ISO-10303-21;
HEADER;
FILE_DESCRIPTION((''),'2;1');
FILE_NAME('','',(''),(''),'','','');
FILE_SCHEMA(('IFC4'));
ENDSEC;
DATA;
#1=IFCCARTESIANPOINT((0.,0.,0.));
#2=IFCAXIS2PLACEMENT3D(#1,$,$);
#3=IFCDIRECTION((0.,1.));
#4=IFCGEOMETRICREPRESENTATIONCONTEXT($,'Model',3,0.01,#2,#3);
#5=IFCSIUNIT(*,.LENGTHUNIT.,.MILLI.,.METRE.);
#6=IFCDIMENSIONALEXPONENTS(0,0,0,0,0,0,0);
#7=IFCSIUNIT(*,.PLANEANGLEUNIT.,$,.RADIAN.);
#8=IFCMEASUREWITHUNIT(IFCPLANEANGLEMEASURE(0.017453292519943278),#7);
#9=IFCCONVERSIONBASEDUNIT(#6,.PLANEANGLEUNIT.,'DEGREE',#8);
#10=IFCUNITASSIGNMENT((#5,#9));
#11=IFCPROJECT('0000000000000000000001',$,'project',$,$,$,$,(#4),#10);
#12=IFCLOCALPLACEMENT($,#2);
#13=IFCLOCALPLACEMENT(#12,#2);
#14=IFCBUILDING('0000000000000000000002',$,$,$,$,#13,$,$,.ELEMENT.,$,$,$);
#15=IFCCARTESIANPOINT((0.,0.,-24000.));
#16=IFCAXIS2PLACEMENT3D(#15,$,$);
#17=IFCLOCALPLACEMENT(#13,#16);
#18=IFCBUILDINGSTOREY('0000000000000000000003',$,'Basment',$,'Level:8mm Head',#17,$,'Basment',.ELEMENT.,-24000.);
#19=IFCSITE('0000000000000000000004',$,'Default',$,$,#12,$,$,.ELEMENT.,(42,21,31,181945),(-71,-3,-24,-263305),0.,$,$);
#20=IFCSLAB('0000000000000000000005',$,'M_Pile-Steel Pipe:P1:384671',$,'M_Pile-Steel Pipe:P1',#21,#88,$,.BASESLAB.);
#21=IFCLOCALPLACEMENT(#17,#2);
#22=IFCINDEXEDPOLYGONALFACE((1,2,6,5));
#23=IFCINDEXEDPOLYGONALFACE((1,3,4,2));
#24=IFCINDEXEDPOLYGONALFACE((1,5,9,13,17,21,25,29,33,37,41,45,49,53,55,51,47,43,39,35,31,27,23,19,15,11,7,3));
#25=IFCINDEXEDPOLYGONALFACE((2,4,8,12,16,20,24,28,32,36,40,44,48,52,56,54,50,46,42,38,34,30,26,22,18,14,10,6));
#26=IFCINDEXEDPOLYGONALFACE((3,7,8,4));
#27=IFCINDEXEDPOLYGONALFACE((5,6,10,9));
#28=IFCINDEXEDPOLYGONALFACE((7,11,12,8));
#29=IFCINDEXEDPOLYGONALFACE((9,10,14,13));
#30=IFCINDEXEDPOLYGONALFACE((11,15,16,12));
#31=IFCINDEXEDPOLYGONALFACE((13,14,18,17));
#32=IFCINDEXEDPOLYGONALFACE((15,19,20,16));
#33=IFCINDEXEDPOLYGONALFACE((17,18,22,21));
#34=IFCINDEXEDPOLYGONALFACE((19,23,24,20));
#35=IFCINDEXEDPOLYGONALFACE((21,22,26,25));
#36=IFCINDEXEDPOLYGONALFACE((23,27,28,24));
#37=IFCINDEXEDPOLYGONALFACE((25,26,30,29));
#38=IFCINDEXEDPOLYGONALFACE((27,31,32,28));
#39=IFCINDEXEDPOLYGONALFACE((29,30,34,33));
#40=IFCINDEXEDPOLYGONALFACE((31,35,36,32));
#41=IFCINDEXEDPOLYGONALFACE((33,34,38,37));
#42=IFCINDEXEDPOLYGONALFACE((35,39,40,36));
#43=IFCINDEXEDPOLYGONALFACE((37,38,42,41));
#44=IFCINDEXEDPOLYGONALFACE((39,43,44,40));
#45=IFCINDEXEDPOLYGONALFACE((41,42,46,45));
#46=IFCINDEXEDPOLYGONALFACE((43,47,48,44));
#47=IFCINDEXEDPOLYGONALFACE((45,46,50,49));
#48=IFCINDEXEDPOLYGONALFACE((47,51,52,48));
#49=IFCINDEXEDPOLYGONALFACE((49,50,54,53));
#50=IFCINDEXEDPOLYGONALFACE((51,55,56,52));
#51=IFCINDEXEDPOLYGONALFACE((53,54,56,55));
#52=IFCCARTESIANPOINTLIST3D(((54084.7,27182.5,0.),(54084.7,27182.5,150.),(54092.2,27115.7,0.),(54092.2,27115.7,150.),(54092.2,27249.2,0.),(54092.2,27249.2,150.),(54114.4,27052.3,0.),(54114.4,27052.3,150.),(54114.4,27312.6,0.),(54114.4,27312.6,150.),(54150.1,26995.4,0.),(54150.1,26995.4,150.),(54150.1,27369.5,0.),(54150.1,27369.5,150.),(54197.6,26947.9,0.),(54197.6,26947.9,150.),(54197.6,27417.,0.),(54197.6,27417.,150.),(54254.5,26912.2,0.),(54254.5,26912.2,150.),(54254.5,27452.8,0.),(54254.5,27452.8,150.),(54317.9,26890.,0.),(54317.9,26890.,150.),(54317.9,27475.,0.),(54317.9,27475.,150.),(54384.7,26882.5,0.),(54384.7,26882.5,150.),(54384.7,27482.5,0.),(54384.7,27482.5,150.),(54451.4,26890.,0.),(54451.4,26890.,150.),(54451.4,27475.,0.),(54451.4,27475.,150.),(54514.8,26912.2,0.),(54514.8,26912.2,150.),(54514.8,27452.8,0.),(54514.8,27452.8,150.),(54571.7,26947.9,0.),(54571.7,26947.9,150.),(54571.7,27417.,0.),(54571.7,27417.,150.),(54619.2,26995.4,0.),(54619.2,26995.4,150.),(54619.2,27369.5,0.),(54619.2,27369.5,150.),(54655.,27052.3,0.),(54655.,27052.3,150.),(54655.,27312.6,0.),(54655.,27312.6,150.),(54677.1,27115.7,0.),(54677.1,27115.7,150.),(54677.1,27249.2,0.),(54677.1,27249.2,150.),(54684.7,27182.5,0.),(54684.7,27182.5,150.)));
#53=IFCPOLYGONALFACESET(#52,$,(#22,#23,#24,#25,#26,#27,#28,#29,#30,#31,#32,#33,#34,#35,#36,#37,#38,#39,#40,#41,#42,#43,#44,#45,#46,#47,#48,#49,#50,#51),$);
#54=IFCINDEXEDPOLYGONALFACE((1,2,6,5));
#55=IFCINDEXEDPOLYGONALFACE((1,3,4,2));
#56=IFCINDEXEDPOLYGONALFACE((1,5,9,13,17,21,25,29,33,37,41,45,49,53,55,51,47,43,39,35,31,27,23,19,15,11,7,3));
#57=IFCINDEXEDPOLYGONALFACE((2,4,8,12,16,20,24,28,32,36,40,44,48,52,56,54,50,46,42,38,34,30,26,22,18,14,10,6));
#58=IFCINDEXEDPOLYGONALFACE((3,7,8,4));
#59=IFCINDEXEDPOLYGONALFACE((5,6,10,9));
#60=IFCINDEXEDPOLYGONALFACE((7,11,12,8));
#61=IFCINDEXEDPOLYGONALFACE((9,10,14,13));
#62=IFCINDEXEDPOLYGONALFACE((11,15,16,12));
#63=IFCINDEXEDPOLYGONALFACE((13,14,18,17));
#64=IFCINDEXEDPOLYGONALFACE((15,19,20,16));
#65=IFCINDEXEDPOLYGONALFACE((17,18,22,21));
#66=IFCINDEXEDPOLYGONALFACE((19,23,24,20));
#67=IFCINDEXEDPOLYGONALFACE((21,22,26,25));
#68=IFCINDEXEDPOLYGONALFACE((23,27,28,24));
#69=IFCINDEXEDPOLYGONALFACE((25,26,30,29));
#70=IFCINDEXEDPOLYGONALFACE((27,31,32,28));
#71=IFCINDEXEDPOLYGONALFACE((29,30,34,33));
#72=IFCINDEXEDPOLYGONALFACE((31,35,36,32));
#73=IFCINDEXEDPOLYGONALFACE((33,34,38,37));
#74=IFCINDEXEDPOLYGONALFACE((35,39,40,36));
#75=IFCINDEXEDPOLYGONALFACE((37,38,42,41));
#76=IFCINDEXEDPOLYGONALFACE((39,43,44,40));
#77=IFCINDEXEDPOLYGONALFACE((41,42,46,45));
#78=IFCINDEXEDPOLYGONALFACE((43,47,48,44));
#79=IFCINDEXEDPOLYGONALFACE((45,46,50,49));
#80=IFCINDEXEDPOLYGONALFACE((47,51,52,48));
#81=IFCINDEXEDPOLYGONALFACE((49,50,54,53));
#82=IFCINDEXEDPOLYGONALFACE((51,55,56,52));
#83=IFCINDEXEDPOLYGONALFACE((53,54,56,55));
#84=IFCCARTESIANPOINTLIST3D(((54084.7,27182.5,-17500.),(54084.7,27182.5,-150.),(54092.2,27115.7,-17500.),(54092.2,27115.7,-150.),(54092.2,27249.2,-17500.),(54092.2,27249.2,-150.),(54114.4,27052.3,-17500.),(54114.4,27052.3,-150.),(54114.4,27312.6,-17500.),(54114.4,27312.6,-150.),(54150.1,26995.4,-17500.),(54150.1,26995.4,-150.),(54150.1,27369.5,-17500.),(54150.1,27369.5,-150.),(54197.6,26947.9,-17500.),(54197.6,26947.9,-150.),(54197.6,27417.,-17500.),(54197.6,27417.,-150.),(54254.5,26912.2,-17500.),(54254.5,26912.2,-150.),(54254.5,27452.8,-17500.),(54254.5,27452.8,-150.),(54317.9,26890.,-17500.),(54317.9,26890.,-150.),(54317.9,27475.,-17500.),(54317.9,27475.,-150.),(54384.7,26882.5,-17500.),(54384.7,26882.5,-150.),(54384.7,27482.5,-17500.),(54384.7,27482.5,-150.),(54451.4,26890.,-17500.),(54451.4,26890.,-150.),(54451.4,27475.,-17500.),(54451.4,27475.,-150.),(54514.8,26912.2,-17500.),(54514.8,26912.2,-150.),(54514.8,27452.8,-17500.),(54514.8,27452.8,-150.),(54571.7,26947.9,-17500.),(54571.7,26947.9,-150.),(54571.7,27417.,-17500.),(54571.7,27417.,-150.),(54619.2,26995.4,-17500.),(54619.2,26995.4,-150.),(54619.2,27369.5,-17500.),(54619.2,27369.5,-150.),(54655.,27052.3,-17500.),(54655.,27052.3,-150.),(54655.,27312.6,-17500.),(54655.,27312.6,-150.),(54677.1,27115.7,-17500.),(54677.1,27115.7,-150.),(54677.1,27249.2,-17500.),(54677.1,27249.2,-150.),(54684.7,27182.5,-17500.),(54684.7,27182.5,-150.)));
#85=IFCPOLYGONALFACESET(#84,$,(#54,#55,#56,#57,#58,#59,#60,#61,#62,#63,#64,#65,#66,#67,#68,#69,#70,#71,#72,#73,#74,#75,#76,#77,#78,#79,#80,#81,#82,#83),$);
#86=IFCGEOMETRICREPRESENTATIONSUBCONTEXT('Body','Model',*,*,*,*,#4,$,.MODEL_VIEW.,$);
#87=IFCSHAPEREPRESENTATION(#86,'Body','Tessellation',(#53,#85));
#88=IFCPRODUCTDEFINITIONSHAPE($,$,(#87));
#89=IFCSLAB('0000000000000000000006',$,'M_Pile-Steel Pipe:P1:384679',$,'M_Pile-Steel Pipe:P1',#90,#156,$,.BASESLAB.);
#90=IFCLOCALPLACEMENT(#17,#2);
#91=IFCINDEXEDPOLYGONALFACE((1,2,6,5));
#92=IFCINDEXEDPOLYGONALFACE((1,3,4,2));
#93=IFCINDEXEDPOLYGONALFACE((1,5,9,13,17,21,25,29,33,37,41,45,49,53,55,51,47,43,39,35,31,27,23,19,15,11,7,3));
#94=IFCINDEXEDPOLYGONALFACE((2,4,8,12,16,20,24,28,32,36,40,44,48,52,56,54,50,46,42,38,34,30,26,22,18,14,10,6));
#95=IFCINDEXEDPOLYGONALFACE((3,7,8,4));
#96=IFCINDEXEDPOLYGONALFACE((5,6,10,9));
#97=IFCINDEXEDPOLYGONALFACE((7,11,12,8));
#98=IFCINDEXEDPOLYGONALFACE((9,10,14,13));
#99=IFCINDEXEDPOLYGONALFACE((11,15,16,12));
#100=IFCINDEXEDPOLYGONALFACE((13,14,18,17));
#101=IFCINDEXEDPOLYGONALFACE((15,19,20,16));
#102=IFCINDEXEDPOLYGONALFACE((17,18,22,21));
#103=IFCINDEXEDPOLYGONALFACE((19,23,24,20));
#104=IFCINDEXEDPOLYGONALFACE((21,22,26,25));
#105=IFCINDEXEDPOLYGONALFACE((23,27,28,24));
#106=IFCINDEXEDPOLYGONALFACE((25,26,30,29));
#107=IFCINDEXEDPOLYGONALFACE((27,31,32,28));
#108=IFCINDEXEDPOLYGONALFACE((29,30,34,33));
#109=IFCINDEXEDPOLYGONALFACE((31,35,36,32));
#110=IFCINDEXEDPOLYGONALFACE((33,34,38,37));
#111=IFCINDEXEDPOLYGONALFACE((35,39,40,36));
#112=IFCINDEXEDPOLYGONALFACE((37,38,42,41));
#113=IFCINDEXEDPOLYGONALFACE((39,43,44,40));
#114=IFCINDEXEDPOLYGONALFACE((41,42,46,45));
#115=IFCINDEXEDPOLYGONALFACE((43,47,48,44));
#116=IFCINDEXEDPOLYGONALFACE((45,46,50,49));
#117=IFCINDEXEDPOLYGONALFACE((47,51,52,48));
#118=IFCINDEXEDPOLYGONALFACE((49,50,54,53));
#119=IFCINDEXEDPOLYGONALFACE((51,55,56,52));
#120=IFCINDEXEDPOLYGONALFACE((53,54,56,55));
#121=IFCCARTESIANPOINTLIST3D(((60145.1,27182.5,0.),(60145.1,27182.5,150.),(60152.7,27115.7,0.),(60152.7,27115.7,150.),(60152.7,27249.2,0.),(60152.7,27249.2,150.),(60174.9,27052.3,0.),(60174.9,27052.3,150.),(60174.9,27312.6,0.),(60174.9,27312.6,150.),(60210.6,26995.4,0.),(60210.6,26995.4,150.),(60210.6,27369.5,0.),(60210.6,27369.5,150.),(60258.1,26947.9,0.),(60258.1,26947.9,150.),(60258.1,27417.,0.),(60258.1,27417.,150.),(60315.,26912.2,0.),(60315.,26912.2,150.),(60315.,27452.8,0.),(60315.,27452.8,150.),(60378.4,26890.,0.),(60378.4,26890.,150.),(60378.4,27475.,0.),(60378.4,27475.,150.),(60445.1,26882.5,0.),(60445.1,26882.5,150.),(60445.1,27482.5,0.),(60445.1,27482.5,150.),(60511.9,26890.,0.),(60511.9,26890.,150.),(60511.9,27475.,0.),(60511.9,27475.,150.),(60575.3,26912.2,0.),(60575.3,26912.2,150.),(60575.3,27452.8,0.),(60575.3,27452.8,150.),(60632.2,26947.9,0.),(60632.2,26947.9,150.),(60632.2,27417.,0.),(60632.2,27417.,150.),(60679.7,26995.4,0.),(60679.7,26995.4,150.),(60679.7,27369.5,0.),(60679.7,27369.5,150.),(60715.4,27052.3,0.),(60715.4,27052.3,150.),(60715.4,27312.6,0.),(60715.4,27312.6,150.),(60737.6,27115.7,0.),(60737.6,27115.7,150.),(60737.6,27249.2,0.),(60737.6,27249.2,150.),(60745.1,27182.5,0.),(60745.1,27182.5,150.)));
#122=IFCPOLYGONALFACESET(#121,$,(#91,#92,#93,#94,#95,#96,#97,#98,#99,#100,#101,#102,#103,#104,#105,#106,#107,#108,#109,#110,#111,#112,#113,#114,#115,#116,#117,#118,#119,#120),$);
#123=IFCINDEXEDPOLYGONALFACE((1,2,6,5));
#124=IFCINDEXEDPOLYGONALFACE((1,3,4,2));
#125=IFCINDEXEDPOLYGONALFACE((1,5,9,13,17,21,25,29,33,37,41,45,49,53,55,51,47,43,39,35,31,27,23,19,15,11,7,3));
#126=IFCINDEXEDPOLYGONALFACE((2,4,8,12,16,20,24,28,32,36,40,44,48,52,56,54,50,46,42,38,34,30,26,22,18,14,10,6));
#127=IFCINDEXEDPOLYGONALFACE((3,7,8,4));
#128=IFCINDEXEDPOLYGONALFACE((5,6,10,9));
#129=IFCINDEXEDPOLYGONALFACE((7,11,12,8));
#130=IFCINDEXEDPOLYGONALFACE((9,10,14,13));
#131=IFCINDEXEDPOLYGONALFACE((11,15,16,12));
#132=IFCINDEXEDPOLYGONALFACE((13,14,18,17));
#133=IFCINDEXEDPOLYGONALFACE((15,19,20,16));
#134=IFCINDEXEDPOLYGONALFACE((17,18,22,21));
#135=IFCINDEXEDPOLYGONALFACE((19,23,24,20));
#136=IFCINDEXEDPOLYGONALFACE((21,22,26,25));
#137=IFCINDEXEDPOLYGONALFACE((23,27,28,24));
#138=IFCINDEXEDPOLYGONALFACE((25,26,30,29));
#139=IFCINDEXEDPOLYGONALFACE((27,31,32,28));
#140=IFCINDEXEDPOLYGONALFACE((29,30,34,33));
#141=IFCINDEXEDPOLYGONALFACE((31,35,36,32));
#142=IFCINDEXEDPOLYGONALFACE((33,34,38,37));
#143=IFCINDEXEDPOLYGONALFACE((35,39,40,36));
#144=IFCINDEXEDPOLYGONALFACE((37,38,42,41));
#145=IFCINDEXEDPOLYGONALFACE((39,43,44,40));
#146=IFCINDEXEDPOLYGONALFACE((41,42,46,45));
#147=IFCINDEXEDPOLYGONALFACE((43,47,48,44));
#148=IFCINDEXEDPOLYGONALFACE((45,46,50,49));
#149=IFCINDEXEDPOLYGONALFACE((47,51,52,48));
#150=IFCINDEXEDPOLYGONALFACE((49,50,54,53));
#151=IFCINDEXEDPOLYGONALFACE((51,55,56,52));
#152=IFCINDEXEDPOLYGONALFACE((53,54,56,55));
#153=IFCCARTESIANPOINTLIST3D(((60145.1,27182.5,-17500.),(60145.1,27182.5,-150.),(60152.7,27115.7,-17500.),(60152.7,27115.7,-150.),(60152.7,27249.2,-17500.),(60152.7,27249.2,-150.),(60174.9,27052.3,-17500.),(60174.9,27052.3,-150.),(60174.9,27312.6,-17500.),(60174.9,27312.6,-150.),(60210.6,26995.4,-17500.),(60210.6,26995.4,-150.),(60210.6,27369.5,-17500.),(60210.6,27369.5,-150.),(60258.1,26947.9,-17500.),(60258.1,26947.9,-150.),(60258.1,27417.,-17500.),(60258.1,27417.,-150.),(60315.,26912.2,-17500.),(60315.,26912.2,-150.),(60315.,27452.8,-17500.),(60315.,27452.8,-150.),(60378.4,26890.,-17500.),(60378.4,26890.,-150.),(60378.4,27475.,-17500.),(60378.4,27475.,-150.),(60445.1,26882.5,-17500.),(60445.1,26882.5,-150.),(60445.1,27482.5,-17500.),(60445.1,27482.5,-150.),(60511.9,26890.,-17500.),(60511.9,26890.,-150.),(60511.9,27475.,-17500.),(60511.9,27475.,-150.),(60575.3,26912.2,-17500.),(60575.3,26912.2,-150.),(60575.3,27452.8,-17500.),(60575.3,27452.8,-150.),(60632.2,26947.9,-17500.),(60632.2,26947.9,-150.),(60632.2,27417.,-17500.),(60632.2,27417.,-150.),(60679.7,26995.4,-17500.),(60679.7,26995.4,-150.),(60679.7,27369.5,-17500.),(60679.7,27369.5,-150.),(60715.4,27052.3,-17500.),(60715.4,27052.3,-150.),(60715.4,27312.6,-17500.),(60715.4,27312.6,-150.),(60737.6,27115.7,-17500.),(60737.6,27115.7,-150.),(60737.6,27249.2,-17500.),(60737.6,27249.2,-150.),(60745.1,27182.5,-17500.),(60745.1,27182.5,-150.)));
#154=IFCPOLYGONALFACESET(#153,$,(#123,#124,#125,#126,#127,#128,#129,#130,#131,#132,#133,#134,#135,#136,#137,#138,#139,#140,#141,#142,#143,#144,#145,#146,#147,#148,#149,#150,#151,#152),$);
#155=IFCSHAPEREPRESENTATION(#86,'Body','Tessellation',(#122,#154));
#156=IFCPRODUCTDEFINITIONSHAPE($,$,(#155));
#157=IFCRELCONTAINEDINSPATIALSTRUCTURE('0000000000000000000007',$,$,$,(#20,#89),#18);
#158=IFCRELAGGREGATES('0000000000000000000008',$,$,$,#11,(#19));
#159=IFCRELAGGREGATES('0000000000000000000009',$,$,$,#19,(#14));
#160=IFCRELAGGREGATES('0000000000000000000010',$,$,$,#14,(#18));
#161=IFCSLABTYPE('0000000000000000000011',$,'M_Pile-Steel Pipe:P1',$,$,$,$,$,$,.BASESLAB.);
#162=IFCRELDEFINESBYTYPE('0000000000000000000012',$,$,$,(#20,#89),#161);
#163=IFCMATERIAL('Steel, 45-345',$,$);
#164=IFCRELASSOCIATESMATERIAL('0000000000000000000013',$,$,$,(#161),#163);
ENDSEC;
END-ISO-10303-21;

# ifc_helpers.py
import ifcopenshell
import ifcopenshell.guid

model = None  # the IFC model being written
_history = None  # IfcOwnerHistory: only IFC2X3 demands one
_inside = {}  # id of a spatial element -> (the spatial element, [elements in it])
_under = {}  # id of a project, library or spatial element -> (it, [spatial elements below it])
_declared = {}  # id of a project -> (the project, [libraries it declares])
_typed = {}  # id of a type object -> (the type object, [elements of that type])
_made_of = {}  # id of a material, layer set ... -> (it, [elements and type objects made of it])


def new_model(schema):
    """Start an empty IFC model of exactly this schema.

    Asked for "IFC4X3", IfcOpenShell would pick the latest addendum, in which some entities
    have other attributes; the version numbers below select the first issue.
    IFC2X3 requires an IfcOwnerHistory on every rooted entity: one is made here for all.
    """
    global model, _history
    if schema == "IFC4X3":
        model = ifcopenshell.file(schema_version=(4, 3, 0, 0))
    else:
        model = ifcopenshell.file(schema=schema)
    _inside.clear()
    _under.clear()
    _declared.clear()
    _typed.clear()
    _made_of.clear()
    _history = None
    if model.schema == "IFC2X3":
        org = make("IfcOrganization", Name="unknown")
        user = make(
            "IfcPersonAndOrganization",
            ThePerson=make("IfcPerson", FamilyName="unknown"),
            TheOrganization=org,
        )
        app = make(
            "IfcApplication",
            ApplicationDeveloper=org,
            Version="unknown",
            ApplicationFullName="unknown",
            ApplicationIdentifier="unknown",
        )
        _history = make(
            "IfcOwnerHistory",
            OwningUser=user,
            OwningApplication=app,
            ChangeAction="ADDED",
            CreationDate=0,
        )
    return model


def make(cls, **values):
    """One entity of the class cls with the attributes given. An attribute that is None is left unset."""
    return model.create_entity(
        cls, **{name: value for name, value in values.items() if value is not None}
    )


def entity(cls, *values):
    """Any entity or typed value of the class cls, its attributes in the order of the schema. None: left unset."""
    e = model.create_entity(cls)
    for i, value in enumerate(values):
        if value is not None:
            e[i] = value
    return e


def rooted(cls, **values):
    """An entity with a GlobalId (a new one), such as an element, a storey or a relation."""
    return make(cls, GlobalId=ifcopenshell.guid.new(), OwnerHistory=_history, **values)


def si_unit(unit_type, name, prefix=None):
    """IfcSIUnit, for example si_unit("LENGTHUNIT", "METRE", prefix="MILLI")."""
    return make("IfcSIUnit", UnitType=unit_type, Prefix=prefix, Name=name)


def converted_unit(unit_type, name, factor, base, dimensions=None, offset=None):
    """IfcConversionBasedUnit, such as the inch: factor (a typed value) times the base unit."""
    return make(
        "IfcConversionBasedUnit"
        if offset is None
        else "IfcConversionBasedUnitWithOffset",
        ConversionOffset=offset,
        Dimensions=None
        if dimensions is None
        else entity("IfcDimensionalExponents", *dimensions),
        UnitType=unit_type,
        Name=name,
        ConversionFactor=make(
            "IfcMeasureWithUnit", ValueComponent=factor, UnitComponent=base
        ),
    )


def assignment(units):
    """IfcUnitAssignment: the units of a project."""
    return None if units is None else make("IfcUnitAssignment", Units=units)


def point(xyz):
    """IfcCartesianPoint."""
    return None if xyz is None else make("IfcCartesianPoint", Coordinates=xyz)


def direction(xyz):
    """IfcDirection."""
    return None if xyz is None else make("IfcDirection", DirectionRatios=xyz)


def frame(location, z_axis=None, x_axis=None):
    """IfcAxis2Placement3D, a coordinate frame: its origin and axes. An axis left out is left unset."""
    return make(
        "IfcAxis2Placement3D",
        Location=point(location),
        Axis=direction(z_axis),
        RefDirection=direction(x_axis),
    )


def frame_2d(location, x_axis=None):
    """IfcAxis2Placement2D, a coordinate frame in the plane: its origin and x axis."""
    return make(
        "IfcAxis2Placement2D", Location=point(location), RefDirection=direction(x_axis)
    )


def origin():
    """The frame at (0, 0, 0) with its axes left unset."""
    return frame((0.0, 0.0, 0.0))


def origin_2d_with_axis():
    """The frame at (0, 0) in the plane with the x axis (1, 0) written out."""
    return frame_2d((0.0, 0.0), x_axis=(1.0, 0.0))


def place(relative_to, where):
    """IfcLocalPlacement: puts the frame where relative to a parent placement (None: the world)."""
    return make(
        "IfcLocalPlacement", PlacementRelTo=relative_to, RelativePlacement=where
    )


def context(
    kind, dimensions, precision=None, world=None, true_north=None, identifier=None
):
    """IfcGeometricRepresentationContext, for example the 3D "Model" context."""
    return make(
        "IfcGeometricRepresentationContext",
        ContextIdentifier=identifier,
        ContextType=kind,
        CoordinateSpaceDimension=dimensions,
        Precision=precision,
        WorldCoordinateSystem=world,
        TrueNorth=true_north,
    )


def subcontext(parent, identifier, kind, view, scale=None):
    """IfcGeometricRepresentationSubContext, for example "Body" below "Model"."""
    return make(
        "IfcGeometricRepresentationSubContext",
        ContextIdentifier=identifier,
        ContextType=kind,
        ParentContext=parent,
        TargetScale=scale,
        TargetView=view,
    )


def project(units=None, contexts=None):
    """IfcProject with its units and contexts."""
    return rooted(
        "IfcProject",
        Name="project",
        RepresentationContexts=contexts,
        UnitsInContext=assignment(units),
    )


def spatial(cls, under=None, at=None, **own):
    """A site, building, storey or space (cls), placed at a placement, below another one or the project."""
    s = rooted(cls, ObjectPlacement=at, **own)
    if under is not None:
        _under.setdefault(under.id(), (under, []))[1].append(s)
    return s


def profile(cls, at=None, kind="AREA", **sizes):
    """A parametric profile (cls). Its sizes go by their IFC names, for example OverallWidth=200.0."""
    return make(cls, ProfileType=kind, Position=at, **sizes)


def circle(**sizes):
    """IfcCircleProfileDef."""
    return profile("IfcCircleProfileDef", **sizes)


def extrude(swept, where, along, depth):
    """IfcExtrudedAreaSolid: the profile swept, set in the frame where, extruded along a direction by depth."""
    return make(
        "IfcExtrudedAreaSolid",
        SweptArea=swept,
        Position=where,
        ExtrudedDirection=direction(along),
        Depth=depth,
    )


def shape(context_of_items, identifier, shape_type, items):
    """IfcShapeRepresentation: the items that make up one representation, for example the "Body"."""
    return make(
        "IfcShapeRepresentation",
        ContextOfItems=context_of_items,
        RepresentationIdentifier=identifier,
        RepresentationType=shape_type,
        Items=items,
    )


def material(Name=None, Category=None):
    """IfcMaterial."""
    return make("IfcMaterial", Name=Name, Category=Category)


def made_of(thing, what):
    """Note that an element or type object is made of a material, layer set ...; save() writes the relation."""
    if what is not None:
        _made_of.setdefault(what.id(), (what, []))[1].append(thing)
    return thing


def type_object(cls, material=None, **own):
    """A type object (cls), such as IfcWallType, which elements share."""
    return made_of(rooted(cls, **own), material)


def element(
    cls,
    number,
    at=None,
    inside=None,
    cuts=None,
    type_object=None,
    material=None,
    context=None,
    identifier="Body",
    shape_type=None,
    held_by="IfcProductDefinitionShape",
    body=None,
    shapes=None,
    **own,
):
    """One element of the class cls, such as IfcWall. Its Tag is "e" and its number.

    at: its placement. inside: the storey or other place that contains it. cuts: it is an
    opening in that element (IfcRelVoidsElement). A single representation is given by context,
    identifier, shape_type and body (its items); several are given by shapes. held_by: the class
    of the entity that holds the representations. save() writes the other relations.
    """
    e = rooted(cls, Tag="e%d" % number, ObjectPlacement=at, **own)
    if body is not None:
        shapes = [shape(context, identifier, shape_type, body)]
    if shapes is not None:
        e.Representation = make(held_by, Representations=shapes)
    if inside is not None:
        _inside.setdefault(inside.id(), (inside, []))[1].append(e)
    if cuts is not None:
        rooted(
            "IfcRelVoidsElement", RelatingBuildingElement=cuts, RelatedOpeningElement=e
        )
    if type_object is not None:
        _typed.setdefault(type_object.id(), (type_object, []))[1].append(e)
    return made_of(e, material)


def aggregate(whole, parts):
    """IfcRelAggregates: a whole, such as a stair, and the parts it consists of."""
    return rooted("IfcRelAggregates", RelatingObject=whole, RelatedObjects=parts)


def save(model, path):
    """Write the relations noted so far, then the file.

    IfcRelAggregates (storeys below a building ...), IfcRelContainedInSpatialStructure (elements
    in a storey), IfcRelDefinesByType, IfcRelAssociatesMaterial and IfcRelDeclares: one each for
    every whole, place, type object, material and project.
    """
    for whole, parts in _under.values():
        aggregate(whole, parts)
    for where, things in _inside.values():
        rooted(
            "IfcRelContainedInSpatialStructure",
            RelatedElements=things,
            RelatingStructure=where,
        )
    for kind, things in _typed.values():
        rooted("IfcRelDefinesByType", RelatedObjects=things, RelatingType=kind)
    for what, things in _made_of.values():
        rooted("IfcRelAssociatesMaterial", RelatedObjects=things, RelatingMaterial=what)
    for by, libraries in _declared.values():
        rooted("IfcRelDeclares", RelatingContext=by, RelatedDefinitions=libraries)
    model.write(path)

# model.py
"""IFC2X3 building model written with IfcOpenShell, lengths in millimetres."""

from ifc_helpers import new_model, entity, si_unit, converted_unit, direction, frame, origin, origin_2d_with_axis, place, context, subcontext, project, spatial, circle, extrude, material, type_object, element, save


model = new_model("IFC2X3")

# Units and contexts
model_context = context("Model", 3, precision=0.01, world=origin(), true_north=direction((0.0, 1.0)))
body_context = subcontext(model_context, "Body", "Model", "MODEL_VIEW")
ifc_project = project(units=[si_unit("LENGTHUNIT", "METRE", prefix="MILLI"), converted_unit("PLANEANGLEUNIT", "DEGREE", entity("IfcPlaneAngleMeasure", 0.017453292519943278), si_unit("PLANEANGLEUNIT", "RADIAN"), dimensions=[0, 0, 0, 0, 0, 0, 0])], contexts=[model_context])

# Site, building, storey
site_placement = place(None, origin())
site = spatial("IfcSite", under=ifc_project, at=site_placement, Name="Default", CompositionType="ELEMENT", RefLatitude=(42, 21, 31, 181945), RefLongitude=(-71, -3, -24, -263305), RefElevation=0.0)
building_placement = place(site_placement, origin())
building = spatial("IfcBuilding", under=site, at=building_placement, CompositionType="ELEMENT")
storey_placement = place(building_placement, frame((0.0, 0.0, -24000.0)))
storey = spatial("IfcBuildingStorey", under=building, at=storey_placement, Name="Basment", ObjectType="Level:8mm Head", LongName="Basment", CompositionType="ELEMENT", Elevation=-24000.0)

# Slabs
ifc_material_1 = material(Name="Steel, 45-345")
slab_type_1 = type_object("IfcSlabType", Name="M_Pile-Steel Pipe:P1", PredefinedType="BASESLAB", material=ifc_material_1)
slab_1_placement = place(storey_placement, origin())
element("IfcSlab", 1, at=slab_1_placement, inside=storey, type_object=slab_type_1, Name="M_Pile-Steel Pipe:P1:384671", ObjectType="M_Pile-Steel Pipe:P1", PredefinedType="BASESLAB", context=body_context, shape_type="SweptSolid", body=[
    extrude(circle(Radius=300.0, at=origin_2d_with_axis()), frame((54384.7, 27182.5, 0.0), z_axis=(0.0, 0.0, 1.0), x_axis=(0.0, 1.0, 0.0)), (0.0, 0.0, 1.0), 150.0),
    extrude(circle(Radius=300.0, at=origin_2d_with_axis()), frame((54384.7, 27182.5, -17500.0), z_axis=(0.0, 0.0, 1.0), x_axis=(0.0, 1.0, 0.0)), (0.0, 0.0, 1.0), 17350.0),
])
slab_2_placement = place(storey_placement, origin())
element("IfcSlab", 2, at=slab_2_placement, inside=storey, type_object=slab_type_1, Name="M_Pile-Steel Pipe:P1:384679", ObjectType="M_Pile-Steel Pipe:P1", PredefinedType="BASESLAB", context=body_context, shape_type="SweptSolid", body=[
    extrude(circle(Radius=300.0, at=origin_2d_with_axis()), frame((60445.1, 27182.5, 0.0), z_axis=(0.0, 0.0, 1.0), x_axis=(0.0, 1.0, 0.0)), (0.0, 0.0, 1.0), 150.0),
    extrude(circle(Radius=300.0, at=origin_2d_with_axis()), frame((60445.1, 27182.5, -17500.0), z_axis=(0.0, 0.0, 1.0), x_axis=(0.0, 1.0, 0.0)), (0.0, 0.0, 1.0), 17350.0),
])

save(model, "model.ifc")
